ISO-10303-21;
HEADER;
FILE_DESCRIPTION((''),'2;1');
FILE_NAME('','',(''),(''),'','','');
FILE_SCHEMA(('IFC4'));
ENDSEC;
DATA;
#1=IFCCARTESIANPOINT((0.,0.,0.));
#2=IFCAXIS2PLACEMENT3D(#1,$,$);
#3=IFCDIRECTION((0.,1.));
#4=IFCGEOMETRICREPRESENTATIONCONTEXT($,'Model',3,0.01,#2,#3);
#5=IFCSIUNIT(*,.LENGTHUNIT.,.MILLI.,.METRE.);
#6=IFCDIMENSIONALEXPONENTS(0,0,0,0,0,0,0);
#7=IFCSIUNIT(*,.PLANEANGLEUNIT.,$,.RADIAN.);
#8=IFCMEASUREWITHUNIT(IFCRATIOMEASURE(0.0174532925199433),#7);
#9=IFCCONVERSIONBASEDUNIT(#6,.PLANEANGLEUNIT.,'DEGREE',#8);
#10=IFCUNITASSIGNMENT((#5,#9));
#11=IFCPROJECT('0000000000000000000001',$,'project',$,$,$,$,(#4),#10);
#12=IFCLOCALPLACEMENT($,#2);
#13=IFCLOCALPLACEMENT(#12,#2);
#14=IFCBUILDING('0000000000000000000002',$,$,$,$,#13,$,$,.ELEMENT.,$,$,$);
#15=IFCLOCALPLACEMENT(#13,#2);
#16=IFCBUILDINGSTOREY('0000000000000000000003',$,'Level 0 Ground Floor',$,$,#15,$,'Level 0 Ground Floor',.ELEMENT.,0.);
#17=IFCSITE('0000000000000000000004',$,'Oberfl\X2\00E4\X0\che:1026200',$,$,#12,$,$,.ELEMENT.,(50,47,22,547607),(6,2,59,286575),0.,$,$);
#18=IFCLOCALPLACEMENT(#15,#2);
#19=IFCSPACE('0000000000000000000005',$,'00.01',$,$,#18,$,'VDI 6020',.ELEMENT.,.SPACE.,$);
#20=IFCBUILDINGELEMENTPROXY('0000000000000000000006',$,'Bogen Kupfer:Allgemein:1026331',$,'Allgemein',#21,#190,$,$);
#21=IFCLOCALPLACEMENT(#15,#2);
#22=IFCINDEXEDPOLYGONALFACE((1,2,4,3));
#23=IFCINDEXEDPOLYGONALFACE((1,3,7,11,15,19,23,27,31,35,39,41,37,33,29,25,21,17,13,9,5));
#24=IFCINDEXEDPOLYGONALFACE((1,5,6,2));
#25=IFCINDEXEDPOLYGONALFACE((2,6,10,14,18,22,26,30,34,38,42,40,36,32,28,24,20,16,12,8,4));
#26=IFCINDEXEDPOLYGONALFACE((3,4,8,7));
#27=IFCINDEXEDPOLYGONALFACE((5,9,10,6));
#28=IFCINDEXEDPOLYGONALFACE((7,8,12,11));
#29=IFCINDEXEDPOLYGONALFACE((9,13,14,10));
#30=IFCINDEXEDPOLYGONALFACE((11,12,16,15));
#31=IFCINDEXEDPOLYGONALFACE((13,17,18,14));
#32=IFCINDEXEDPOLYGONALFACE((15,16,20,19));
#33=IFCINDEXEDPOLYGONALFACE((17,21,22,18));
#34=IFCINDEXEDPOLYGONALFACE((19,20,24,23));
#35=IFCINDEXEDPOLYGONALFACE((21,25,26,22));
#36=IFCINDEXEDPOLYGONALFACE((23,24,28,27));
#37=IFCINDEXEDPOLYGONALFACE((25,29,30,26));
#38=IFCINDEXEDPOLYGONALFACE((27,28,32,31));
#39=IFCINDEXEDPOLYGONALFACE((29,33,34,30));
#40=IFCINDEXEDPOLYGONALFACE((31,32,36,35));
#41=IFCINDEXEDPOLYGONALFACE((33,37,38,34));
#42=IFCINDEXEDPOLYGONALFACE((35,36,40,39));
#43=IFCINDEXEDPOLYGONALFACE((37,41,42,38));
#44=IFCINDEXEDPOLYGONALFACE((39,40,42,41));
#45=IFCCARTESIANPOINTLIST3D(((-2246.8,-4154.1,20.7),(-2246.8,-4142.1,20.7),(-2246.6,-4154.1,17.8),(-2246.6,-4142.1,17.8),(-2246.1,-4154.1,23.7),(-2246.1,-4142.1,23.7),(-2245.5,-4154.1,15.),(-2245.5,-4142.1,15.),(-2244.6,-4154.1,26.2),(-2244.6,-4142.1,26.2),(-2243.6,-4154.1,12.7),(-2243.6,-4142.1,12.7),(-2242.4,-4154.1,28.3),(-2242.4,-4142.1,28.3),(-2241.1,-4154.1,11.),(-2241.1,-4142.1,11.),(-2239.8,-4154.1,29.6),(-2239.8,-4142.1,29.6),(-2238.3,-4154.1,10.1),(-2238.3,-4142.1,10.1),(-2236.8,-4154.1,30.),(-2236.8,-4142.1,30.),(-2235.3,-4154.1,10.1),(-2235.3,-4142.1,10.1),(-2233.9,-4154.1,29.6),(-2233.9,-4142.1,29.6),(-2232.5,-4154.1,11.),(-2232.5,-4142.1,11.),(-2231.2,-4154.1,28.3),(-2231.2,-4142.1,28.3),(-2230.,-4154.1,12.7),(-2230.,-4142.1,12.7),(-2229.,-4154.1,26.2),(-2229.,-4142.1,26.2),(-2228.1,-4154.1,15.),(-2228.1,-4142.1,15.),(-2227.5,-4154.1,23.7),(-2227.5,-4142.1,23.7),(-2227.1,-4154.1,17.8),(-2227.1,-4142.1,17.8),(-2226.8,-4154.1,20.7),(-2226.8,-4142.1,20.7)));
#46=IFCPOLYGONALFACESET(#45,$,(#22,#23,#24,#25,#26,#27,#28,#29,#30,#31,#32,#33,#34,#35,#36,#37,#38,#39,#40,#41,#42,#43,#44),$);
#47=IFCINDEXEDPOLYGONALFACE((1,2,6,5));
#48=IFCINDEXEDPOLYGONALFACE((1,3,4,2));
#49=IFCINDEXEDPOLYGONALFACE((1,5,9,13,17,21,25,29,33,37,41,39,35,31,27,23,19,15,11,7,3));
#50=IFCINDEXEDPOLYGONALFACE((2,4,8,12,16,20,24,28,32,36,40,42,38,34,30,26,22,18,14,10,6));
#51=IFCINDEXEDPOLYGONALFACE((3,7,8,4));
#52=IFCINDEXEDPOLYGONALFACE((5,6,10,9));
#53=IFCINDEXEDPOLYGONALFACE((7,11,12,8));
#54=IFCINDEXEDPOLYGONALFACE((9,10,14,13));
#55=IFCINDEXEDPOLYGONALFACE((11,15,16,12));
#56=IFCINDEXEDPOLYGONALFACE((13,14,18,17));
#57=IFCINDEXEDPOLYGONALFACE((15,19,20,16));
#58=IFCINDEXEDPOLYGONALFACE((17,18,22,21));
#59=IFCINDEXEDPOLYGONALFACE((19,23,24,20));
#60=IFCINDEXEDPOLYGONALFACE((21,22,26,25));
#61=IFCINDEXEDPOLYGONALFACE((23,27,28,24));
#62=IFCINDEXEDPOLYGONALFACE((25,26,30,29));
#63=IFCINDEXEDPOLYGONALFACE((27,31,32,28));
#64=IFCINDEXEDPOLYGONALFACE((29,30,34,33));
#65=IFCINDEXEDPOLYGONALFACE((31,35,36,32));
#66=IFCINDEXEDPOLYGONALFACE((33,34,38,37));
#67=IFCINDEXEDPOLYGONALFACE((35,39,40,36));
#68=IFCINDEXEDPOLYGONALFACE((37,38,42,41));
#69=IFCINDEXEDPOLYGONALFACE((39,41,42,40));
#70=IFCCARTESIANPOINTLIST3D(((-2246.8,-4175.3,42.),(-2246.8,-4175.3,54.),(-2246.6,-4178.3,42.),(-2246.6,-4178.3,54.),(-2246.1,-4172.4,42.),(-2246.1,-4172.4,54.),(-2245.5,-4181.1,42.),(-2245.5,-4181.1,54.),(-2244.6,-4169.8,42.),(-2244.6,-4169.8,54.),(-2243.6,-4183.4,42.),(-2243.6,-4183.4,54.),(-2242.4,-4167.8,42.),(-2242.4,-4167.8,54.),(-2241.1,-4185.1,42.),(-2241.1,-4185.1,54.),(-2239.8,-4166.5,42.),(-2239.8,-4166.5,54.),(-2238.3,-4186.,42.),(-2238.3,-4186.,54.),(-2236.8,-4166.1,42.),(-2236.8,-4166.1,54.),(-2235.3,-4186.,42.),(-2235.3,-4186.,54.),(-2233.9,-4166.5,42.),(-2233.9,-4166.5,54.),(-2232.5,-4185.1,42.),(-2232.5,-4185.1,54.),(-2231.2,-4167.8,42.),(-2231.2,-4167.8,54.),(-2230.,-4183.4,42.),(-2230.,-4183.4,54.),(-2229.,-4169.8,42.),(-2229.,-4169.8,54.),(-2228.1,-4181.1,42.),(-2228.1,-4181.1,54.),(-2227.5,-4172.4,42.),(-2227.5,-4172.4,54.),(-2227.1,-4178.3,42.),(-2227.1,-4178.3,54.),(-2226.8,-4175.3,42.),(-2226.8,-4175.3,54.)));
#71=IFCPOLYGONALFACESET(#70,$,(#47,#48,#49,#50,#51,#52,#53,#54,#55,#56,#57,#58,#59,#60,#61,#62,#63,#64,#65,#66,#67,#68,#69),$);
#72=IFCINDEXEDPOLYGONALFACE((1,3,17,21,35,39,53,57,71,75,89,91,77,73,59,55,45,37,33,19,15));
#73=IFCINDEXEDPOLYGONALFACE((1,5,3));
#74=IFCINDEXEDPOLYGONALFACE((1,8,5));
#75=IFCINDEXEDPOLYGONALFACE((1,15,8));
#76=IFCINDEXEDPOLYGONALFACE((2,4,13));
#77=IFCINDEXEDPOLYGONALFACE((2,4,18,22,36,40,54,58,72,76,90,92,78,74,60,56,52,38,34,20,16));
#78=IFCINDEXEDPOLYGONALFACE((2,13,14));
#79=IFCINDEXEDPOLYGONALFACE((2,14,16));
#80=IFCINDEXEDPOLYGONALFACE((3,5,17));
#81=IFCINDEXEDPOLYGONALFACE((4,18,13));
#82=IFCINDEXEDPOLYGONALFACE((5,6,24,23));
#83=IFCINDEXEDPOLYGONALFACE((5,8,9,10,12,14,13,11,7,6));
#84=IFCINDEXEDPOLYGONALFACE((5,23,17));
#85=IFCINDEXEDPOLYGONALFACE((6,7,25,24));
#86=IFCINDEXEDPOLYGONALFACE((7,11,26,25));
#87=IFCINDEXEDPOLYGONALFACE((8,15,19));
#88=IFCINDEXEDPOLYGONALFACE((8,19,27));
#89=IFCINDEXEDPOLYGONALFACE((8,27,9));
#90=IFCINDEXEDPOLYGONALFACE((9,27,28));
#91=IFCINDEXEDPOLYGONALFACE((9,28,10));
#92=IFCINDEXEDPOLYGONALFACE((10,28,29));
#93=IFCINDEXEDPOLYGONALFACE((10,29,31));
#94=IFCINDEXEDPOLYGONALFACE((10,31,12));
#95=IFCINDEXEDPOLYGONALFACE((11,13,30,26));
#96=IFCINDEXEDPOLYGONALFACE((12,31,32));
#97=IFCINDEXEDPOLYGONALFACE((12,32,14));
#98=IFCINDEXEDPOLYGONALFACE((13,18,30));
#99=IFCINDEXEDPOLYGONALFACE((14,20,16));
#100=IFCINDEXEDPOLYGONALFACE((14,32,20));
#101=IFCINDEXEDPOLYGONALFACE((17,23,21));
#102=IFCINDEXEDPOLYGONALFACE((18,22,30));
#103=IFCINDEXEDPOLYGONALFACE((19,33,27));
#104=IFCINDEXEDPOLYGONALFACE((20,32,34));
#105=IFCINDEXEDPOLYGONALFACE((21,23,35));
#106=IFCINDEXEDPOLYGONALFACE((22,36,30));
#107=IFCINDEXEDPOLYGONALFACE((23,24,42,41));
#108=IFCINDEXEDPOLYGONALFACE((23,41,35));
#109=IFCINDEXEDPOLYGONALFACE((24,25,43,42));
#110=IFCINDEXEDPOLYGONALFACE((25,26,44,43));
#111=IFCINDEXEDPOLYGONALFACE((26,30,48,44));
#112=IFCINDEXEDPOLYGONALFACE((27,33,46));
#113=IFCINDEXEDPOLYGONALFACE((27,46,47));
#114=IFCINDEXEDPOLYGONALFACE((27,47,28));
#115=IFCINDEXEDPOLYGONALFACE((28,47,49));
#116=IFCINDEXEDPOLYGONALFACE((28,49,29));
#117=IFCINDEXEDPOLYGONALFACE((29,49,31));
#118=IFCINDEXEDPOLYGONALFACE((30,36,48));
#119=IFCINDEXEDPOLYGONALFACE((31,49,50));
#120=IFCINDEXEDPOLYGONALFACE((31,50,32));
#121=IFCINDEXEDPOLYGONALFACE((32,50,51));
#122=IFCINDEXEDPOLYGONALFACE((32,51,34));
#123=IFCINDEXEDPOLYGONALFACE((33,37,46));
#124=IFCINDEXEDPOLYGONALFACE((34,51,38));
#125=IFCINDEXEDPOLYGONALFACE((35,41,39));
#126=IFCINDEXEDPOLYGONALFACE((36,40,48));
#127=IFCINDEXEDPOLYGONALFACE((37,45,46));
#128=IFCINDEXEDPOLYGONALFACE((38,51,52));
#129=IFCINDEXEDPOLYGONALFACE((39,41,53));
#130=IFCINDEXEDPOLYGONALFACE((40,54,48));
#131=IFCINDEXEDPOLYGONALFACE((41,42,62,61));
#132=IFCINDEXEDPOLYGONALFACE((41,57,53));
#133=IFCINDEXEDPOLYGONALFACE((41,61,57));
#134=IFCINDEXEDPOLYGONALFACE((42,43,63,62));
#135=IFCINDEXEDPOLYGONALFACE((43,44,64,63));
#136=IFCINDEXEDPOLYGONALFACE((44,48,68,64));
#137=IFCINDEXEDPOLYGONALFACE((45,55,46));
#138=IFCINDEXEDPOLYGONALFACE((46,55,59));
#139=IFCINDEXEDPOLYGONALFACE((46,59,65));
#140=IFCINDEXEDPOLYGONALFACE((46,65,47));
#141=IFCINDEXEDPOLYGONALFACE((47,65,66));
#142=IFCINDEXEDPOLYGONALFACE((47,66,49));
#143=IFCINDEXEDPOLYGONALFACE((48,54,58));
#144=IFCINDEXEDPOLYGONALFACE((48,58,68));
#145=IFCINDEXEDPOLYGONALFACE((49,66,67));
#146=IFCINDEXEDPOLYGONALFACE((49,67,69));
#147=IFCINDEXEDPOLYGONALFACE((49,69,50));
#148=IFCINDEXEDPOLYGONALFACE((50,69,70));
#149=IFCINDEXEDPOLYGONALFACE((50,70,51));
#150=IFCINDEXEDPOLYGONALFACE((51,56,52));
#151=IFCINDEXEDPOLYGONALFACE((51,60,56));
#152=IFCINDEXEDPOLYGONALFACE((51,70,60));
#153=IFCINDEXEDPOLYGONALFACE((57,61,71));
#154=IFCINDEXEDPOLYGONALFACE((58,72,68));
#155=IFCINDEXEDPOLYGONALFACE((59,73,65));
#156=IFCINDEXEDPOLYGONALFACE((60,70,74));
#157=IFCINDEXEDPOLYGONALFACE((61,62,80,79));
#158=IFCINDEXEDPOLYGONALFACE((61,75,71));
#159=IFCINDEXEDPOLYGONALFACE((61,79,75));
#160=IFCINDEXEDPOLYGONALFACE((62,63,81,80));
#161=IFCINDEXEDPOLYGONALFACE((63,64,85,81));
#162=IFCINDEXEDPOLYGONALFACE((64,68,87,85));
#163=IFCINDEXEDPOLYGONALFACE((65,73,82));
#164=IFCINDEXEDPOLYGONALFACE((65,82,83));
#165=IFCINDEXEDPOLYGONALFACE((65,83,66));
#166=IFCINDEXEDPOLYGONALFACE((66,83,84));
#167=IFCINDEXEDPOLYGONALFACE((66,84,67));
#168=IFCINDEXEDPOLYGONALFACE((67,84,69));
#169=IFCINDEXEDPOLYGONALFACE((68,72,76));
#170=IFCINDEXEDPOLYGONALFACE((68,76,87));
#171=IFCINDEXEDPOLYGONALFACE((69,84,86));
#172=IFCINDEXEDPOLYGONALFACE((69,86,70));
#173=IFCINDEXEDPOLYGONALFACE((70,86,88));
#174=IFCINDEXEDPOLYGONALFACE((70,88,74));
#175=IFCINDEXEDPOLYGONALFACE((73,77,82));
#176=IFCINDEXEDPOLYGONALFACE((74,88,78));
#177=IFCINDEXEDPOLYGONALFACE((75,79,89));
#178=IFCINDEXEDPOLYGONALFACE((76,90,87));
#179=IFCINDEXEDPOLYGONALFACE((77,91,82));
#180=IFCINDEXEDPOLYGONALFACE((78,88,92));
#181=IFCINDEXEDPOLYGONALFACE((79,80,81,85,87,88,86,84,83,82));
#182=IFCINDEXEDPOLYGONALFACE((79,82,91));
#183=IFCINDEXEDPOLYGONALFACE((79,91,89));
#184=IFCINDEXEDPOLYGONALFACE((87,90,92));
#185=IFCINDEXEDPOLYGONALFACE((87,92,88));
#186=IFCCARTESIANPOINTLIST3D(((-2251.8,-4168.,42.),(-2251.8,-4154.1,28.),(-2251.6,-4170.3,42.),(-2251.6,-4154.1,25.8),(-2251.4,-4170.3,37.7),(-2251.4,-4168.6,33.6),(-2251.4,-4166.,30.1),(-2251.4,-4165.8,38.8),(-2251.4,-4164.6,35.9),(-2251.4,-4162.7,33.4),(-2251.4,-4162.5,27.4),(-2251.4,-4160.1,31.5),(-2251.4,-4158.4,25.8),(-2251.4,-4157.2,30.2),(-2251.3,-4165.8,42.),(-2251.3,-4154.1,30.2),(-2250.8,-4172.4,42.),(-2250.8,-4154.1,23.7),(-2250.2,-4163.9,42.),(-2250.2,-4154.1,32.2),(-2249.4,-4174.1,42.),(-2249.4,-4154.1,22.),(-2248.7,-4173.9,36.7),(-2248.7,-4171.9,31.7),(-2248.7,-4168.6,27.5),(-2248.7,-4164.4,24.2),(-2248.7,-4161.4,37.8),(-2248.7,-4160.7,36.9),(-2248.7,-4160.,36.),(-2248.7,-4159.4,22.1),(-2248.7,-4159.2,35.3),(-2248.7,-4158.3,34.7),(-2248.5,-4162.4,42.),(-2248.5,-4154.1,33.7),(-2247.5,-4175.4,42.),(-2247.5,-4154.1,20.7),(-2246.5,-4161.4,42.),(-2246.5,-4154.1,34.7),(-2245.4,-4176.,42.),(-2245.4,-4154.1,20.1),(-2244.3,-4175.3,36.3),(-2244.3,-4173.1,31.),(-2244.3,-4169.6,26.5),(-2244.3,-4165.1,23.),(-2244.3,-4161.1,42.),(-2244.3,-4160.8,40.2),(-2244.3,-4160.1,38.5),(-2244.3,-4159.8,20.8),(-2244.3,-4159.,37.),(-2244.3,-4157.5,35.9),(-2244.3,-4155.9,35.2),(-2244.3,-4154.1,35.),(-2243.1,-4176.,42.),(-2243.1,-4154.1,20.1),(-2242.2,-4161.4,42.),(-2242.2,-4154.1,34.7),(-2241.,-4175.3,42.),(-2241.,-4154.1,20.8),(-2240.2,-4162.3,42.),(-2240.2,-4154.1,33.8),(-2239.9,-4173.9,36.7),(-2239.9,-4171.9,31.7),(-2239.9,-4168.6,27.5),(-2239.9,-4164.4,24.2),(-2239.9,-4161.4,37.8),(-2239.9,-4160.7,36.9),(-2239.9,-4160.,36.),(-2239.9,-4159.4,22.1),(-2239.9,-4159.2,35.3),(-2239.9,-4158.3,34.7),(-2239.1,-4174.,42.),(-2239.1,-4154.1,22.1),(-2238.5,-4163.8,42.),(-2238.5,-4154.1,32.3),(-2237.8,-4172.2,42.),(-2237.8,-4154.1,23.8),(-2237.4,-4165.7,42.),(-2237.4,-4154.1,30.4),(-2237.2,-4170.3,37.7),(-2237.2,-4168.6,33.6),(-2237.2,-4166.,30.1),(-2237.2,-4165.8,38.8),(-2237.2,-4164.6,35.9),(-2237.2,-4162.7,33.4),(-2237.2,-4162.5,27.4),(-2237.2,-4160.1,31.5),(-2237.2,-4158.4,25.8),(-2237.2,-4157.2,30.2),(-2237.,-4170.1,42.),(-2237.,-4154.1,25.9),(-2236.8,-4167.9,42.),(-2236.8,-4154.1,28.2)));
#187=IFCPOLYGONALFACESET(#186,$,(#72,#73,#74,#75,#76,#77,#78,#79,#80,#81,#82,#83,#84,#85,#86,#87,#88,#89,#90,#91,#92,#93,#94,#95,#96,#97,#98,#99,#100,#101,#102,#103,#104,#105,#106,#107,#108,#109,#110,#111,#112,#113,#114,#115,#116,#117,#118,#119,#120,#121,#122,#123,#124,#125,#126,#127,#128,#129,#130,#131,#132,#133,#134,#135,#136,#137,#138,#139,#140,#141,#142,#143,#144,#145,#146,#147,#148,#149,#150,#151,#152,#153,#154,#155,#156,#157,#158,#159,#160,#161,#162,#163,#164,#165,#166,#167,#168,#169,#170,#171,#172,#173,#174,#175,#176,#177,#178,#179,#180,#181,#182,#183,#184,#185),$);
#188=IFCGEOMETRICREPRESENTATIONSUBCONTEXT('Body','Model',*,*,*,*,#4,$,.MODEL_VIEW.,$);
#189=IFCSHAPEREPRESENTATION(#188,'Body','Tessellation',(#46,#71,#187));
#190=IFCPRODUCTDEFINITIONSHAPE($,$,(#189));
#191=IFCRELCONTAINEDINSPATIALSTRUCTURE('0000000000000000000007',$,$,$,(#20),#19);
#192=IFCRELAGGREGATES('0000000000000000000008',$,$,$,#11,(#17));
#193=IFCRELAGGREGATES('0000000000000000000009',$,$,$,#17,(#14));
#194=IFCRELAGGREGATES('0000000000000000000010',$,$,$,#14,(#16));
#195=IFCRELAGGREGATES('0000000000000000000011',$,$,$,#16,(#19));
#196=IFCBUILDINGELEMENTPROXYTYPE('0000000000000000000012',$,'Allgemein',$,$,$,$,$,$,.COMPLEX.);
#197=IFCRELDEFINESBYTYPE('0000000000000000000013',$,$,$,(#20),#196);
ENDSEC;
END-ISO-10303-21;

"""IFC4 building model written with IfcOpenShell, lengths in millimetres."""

from ifc_helpers import new_model, entity, si_unit, converted_unit, direction, frame, frame_2d, origin, place, context, subcontext, project, spatial, circle, extrude, source, transform, mapped, type_object, type_shapes, element, save


model = new_model("IFC4")

# Units and contexts
model_context = context("Model", 3, precision=0.01, world=origin(), true_north=direction((0.0, 1.0)))
body_context = subcontext(model_context, "Body", "Model", "MODEL_VIEW")
ifc_project = project(units=[si_unit("LENGTHUNIT", "METRE", prefix="MILLI"), converted_unit("PLANEANGLEUNIT", "DEGREE", entity("IfcRatioMeasure", 0.0174532925199433), si_unit("PLANEANGLEUNIT", "RADIAN"), dimensions=[0, 0, 0, 0, 0, 0, 0])], contexts=[model_context])

# Site, building, storey
site_placement = place(None, origin())
site = spatial("IfcSite", under=ifc_project, at=site_placement, Name="Oberfläche:1026200", CompositionType="ELEMENT", RefLatitude=(50, 47, 22, 547607), RefLongitude=(6, 2, 59, 286575), RefElevation=0.0)
building_placement = place(site_placement, origin())
building = spatial("IfcBuilding", under=site, at=building_placement, CompositionType="ELEMENT")
storey_placement = place(building_placement, origin())
storey = spatial("IfcBuildingStorey", under=building, at=storey_placement, Name="Level 0 Ground Floor", LongName="Level 0 Ground Floor", CompositionType="ELEMENT", Elevation=0.0)

# Shared definitions
space_placement = place(storey_placement, origin())
space = spatial("IfcSpace", under=storey, at=space_placement, Name="00.01", LongName="VDI 6020", CompositionType="ELEMENT", PredefinedType="SPACE")

# Building element proxy
building_element_proxy_type = type_object("IfcBuildingElementProxyType", Name="Allgemein", PredefinedType="COMPLEX")
ifc_direction = entity("IfcDirection", [0.0, 0.0, -1.0])
trimmed_curve = entity("IfcTrimmedCurve", entity("IfcCircle", entity("IfcAxis2Placement2D", entity("IfcCartesianPoint", [-14.5, 0.0]), entity("IfcDirection", [0.0, 1.0])), 14.5), [entity("IfcParameterValue", 270.0)], [entity("IfcParameterValue", 0.0)], True, "PARAMETER")
shared_shape_1 = source(origin(), body_context, "Body", "SolidModel", [
    extrude(circle(Radius=10.0, at=frame_2d((0.0, 0.0), x_axis=(1.0, 0.0))), frame((0.0, 22.0, 0.0), z_axis=(0.0, 1.0, 0.0), x_axis=(-1.0, 0.0, 0.0)), (0.0, 0.0, 1.0), 12.0),
    extrude(circle(Radius=10.0, at=frame_2d((0.0, 0.0), x_axis=(1.0, 0.0))), frame((-34.0, 0.0, 0.0), z_axis=(1.0, 0.0, 0.0), x_axis=(0.0, 1.0, 0.0)), (0.0, 0.0, 1.0), 12.0),
    entity("IfcSurfaceCurveSweptAreaSolid", entity("IfcCircleProfileDef", "AREA", None, entity("IfcAxis2Placement2D", entity("IfcCartesianPoint", [0.0, 7.5]), entity("IfcDirection", [1.0, 0.0])), 7.5), entity("IfcAxis2Placement3D", entity("IfcCartesianPoint", [-7.5, 22.0, 0.0]), ifc_direction, entity("IfcDirection", [1.0, 0.0, 0.0])), trimmed_curve, 0.0, 90.0, entity("IfcSurfaceOfLinearExtrusion", entity("IfcArbitraryOpenProfileDef", "CURVE", None, trimmed_curve), entity("IfcAxis2Placement3D", entity("IfcCartesianPoint", [0.0, 0.0, -304.8])), ifc_direction, 1.0)),
])
type_shapes(building_element_proxy_type, [shared_shape_1])
for number, where, z_axis, x_axis, name in (
    (1, (-2236.8, -4176.1, 20.0), (1.0, 0.0, 0.0), (0.0, 0.0, -1.0), "Bogen Kupfer:Allgemein:1026331"),
):
    element("IfcBuildingElementProxy", number, at=place(space_placement, frame(where, z_axis=z_axis, x_axis=x_axis)), inside=space, type_object=building_element_proxy_type, Name=name, ObjectType="Allgemein", context=body_context, shape_type="MappedRepresentation", body=[
        mapped(shared_shape_1, transform((0.0, 0.0, 0.0), scale=1.0)),
    ])

save(model, "model.ifc")
